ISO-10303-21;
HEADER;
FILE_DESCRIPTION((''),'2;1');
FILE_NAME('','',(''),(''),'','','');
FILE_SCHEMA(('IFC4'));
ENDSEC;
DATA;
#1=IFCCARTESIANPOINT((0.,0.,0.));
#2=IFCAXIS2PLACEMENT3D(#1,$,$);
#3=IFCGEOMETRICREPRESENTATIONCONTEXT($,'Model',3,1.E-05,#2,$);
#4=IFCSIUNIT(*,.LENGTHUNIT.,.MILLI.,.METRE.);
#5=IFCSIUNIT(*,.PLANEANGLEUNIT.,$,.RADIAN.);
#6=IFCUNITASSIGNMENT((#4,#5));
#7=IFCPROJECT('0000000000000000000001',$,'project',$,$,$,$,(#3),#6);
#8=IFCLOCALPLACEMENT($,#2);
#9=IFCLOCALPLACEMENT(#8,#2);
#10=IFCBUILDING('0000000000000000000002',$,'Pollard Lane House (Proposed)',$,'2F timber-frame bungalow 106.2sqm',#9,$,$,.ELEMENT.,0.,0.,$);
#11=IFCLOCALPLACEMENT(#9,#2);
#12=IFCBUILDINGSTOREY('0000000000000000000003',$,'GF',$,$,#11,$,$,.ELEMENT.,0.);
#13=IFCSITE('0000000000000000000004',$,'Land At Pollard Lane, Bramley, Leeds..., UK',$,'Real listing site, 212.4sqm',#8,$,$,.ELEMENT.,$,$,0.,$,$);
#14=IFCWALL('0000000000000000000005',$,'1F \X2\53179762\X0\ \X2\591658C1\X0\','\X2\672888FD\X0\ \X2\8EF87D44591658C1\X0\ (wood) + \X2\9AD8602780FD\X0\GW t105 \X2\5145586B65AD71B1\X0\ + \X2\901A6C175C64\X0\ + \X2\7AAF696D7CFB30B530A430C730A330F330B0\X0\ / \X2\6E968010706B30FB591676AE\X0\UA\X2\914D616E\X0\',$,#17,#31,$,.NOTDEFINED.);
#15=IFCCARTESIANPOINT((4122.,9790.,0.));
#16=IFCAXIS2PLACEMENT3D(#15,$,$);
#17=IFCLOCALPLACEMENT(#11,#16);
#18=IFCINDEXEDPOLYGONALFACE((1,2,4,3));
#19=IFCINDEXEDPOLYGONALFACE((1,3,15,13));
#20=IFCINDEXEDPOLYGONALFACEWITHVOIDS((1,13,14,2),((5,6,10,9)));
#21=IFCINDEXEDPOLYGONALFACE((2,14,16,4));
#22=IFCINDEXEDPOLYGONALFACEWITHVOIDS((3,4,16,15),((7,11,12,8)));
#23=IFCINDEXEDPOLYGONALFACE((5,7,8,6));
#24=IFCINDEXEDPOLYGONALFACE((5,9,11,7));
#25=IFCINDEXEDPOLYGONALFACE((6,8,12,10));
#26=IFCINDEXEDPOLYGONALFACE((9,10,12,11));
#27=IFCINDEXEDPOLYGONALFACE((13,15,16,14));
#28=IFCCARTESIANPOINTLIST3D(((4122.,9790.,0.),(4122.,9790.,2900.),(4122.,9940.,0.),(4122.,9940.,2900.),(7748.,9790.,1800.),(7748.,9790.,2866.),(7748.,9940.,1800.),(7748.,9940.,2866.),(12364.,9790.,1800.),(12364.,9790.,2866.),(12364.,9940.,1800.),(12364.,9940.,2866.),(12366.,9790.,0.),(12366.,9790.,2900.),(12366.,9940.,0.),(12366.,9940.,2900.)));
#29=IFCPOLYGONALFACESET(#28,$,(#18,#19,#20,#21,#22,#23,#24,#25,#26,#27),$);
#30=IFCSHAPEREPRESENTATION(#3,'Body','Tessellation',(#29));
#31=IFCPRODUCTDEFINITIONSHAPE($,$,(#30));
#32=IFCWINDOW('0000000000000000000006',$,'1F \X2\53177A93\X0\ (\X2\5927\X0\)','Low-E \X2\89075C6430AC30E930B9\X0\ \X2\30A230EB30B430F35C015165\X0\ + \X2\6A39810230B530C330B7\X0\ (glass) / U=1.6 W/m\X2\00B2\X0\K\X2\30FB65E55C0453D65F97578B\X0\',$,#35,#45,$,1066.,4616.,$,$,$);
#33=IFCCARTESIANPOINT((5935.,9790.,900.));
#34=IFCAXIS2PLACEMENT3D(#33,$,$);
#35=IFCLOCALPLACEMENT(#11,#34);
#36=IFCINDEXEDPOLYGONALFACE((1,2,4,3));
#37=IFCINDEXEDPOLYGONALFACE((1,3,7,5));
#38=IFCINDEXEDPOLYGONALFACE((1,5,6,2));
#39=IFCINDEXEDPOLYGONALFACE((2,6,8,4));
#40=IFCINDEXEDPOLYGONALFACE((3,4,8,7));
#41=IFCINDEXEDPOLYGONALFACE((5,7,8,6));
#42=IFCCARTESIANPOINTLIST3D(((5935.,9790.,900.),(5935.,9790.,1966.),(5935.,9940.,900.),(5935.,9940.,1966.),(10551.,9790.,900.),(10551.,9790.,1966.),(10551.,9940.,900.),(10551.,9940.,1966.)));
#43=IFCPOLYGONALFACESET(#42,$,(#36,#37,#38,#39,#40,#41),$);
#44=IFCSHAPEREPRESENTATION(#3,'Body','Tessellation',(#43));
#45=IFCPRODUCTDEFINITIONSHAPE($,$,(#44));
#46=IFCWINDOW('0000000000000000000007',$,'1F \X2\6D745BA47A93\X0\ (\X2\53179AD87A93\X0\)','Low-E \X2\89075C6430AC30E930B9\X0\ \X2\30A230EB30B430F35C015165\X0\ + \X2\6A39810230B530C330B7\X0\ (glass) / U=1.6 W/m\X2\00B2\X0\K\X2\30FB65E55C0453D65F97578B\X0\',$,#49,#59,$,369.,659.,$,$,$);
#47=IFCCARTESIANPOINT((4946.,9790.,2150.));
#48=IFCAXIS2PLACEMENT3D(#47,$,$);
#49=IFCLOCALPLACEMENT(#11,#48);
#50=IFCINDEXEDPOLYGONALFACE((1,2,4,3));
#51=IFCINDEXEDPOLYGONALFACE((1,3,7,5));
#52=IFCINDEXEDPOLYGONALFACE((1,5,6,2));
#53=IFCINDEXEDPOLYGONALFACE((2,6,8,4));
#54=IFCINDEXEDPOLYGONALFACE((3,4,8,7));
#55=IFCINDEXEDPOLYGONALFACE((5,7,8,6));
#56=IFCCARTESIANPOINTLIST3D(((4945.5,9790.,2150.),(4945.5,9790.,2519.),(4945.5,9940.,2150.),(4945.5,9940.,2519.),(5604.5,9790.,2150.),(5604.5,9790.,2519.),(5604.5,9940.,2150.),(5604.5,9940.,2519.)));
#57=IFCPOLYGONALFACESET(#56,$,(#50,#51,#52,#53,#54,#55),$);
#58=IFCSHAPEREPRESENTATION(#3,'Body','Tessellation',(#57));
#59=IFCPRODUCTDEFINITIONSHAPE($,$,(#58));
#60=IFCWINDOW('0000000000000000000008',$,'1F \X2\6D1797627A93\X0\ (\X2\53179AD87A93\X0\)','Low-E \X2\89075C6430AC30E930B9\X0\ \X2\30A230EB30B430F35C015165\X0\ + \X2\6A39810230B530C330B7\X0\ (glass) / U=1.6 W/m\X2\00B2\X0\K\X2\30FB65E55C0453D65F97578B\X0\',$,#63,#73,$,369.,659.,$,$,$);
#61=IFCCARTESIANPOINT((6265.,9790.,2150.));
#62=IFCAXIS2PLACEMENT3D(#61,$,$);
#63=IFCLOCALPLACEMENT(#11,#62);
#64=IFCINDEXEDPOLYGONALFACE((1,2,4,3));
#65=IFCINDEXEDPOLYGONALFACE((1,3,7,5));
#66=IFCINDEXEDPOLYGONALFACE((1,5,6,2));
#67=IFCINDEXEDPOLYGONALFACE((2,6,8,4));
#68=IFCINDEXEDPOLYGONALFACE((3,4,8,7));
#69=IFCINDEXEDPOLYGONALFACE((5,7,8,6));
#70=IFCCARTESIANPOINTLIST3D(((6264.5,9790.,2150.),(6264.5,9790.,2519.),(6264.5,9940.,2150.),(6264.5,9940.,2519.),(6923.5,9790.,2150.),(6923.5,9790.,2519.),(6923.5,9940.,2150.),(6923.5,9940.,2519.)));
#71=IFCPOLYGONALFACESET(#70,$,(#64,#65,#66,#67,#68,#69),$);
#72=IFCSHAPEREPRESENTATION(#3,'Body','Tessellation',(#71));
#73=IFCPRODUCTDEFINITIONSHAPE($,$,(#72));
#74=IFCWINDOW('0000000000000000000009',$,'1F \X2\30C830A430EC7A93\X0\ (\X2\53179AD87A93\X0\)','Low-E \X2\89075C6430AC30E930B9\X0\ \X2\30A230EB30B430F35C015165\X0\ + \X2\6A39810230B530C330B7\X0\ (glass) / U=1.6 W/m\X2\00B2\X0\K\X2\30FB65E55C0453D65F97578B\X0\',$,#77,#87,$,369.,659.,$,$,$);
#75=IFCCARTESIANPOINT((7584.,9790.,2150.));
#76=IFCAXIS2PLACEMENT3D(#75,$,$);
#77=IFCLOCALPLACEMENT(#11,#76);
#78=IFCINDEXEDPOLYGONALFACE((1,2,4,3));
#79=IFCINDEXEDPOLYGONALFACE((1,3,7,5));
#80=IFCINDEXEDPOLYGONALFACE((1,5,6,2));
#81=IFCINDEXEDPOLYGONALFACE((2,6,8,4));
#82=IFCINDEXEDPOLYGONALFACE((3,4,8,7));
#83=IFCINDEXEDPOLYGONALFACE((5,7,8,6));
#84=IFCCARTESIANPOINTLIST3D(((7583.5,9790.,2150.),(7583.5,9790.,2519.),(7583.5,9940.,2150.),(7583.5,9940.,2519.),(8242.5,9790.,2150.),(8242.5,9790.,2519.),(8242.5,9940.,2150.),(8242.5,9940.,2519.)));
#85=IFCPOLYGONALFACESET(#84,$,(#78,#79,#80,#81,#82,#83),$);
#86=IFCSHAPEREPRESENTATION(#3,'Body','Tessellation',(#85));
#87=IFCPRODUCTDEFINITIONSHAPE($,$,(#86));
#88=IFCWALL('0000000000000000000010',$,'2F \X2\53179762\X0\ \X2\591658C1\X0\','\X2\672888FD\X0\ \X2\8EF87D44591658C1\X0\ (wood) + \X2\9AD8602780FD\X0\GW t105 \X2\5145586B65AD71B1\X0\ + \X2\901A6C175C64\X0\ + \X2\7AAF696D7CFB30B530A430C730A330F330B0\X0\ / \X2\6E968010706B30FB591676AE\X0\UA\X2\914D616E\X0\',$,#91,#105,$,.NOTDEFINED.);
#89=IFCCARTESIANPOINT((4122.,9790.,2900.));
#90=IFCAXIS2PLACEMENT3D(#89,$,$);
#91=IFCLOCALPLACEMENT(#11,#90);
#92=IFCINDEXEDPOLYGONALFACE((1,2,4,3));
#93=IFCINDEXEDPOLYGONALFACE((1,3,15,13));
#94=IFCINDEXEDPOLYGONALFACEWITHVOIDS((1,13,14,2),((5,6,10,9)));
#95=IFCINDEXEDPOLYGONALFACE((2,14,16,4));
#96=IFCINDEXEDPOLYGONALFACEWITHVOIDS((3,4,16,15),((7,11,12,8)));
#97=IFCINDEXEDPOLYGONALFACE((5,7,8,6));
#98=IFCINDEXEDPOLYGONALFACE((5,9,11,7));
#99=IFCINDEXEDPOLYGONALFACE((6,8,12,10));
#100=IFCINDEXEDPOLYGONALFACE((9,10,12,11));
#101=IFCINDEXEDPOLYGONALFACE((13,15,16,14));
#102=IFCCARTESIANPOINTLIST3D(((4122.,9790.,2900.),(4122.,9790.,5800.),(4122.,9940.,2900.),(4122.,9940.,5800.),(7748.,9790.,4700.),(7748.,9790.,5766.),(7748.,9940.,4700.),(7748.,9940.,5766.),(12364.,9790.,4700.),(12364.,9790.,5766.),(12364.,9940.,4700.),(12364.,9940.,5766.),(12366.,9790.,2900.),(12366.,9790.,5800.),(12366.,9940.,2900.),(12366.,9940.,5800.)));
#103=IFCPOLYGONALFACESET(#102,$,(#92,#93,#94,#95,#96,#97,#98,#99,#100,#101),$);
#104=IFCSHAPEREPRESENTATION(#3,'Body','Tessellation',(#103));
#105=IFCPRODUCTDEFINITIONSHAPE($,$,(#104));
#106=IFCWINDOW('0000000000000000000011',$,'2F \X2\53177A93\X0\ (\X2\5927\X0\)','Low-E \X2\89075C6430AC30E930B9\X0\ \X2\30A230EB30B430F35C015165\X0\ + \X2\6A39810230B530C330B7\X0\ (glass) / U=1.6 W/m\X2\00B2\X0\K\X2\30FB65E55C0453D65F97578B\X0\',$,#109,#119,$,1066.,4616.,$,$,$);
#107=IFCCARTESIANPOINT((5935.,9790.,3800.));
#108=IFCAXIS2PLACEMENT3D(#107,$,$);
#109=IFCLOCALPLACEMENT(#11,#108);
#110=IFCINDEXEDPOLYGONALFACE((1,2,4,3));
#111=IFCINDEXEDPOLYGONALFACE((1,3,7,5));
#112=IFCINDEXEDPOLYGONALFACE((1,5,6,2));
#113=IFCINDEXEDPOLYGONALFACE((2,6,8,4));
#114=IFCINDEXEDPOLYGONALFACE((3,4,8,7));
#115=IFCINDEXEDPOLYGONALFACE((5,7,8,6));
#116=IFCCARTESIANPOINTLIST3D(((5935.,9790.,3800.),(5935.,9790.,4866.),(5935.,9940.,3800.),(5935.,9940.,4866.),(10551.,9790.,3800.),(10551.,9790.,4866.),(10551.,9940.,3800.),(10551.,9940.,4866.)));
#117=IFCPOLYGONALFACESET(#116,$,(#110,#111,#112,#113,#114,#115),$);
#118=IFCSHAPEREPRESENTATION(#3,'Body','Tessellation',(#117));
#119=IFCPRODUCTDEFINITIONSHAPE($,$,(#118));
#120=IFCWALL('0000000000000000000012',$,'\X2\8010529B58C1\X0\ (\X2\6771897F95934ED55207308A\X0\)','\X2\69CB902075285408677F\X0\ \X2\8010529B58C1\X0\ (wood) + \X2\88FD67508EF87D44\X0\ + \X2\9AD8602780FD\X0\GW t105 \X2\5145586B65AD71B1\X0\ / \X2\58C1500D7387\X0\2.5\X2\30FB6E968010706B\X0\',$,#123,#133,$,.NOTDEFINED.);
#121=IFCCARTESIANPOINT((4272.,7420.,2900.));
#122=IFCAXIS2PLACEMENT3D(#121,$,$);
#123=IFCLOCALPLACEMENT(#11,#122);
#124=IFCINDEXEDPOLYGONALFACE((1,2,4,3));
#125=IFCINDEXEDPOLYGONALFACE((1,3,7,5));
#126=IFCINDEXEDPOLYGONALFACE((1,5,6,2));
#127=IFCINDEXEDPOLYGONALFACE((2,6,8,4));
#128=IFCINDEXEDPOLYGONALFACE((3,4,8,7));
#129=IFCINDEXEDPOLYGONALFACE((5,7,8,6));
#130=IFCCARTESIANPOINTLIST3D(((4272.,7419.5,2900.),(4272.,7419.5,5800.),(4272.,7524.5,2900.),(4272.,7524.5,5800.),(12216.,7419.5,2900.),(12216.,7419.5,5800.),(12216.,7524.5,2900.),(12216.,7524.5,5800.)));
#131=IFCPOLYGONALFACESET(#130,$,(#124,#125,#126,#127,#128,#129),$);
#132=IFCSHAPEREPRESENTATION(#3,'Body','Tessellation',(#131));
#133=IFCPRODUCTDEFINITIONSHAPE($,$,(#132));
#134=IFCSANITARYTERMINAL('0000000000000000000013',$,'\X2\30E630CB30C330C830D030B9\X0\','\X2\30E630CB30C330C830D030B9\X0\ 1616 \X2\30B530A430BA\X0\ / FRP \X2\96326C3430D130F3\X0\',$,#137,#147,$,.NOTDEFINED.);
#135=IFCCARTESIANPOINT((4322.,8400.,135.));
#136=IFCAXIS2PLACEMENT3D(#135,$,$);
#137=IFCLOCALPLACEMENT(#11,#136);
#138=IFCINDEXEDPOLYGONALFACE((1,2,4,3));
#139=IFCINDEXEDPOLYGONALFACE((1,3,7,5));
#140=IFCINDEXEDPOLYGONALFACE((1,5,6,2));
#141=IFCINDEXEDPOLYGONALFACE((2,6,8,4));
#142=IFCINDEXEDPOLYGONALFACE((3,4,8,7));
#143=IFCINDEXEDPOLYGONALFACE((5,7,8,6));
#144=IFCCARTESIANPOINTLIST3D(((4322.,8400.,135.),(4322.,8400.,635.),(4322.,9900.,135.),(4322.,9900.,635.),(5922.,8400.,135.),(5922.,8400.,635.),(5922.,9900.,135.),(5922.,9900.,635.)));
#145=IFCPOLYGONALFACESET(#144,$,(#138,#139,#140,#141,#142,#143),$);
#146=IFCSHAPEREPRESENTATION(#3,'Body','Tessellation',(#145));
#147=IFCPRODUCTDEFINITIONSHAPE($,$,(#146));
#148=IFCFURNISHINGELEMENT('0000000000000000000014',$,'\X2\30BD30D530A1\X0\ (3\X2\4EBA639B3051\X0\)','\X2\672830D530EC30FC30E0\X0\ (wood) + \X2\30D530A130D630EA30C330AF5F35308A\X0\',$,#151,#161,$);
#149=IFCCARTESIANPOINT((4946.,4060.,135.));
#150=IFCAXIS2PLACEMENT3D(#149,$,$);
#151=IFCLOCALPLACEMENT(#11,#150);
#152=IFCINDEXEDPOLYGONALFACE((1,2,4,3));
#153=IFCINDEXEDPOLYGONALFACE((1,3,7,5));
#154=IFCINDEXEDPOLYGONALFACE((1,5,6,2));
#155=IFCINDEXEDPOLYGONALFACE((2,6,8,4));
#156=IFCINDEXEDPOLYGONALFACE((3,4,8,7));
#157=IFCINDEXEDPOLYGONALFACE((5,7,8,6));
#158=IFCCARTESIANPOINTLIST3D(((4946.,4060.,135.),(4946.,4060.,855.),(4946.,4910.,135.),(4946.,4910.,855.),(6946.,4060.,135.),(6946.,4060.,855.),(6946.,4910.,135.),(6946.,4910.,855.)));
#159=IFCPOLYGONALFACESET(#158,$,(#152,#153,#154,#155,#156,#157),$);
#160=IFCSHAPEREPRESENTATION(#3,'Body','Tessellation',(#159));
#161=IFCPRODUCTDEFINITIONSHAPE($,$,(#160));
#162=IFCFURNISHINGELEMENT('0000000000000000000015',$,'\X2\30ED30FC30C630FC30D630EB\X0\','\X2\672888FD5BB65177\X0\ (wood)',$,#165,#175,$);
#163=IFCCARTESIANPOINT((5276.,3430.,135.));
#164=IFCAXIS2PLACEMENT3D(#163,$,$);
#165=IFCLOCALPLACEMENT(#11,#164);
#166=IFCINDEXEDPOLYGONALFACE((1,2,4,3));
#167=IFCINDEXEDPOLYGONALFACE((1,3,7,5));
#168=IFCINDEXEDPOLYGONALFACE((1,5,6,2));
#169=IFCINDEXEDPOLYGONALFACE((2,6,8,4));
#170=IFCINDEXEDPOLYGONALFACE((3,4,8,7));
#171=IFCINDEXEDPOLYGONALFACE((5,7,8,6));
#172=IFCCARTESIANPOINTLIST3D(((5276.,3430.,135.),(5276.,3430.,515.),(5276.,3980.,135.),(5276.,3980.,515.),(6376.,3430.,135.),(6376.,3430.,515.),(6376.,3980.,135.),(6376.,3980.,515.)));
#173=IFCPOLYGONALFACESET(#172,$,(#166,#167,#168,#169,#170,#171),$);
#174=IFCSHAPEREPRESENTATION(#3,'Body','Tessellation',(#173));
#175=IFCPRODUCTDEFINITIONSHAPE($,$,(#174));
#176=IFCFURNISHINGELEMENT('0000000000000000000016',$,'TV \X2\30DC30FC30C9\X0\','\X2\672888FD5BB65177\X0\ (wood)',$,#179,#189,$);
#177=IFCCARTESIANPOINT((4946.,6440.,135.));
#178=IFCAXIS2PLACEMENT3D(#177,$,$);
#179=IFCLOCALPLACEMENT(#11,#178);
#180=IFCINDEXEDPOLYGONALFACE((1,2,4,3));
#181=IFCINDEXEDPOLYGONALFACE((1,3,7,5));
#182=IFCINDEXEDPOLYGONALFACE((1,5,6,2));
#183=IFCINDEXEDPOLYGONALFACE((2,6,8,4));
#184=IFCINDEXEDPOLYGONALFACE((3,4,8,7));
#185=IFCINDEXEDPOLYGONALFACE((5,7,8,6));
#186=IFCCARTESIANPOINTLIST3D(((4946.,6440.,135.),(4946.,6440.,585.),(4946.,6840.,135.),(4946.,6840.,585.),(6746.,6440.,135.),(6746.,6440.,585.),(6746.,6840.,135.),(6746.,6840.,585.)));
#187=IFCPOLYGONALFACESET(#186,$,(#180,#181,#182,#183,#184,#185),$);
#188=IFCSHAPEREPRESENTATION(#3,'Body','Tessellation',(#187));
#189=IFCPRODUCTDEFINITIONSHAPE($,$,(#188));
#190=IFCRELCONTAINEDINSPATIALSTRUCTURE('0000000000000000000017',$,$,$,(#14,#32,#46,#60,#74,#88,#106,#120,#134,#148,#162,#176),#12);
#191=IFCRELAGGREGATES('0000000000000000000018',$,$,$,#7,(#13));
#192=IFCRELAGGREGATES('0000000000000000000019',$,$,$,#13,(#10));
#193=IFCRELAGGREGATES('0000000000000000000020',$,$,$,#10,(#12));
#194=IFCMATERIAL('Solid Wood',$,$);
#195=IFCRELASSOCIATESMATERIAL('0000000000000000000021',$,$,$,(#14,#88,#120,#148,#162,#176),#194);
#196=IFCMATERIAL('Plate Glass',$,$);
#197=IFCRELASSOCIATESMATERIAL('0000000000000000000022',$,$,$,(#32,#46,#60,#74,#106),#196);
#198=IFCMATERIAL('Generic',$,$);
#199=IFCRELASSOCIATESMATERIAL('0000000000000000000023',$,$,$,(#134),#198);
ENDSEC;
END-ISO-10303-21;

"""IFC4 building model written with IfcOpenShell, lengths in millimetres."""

from ifc_helpers import new_model, si_unit, frame, frame_2d, origin, place, context, project, spatial, rectangle, extrude, material, element, fill, save


model = new_model("IFC4")

# Units and contexts
model_context = context("Model", 3, precision=1e-05, world=origin())
ifc_project = project(units=[si_unit("LENGTHUNIT", "METRE", prefix="MILLI"), si_unit("PLANEANGLEUNIT", "RADIAN")], contexts=[model_context])

# Site, building, storey
site_placement = place(None, origin())
site = spatial("IfcSite", under=ifc_project, at=site_placement, Name="Land At Pollard Lane, Bramley, Leeds..., UK", ObjectType="Real listing site, 212.4sqm", CompositionType="ELEMENT", RefElevation=0.0)
building_placement = place(site_placement, origin())
building = spatial("IfcBuilding", under=site, at=building_placement, Name="Pollard Lane House (Proposed)", ObjectType="2F timber-frame bungalow 106.2sqm", CompositionType="ELEMENT", ElevationOfRefHeight=0.0, ElevationOfTerrain=0.0)
storey_placement = place(building_placement, origin())
storey = spatial("IfcBuildingStorey", under=building, at=storey_placement, Name="GF", CompositionType="ELEMENT", Elevation=0.0)

# Wall, openings, windows
ifc_material_1 = material(Name="Solid Wood")
wall_1_placement = place(storey_placement, frame((4122.0, 9790.0, 0.0)))
wall_1 = element("IfcWall", 1, at=wall_1_placement, inside=storey, material=ifc_material_1, Name="1F 北面 外壁", Description="木製 軸組外壁 (wood) + 高性能GW t105 充填断熱 + 通気層 + 窯業系サイディング / 準耐火・外皮UA配慮", PredefinedType="NOTDEFINED", context=model_context, shape_type="SweptSolid", body=[
    extrude(rectangle(XDim=8244.0, YDim=150.0, at=frame_2d((4122.0, 75.0))), frame((4122.0, 9790.0, 0.0)), (0.0, 0.0, 1.0), 2900.0),
])
opening_1_placement = place(storey_placement, frame((5935.0, 9790.0, 900.0)))
opening_1 = element("IfcOpeningElement", 2, at=opening_1_placement, cuts=wall_1, PredefinedType="NOTDEFINED", context=model_context, shape_type="SweptSolid", body=[
    extrude(rectangle(XDim=4616.0, YDim=150.0, at=frame_2d((2308.0, 75.0))), frame((5935.0, 9790.0, 900.0)), (0.0, 0.0, 1.0), 1066.0),
])
opening_2_placement = place(storey_placement, frame((4946.0, 9790.0, 2150.0)))
opening_2 = element("IfcOpeningElement", 3, at=opening_2_placement, cuts=wall_1, PredefinedType="NOTDEFINED", context=model_context, shape_type="SweptSolid", body=[
    extrude(rectangle(XDim=659.0, YDim=150.0, at=frame_2d((329.0, 75.0))), frame((4946.0, 9790.0, 2150.0)), (0.0, 0.0, 1.0), 369.0),
])
opening_3_placement = place(storey_placement, frame((6265.0, 9790.0, 2150.0)))
opening_3 = element("IfcOpeningElement", 4, at=opening_3_placement, cuts=wall_1, PredefinedType="NOTDEFINED", context=model_context, shape_type="SweptSolid", body=[
    extrude(rectangle(XDim=659.0, YDim=150.0, at=frame_2d((329.0, 75.0))), frame((6265.0, 9790.0, 2150.0)), (0.0, 0.0, 1.0), 369.0),
])
opening_4_placement = place(storey_placement, frame((7584.0, 9790.0, 2150.0)))
opening_4 = element("IfcOpeningElement", 5, at=opening_4_placement, cuts=wall_1, PredefinedType="NOTDEFINED", context=model_context, shape_type="SweptSolid", body=[
    extrude(rectangle(XDim=659.0, YDim=150.0, at=frame_2d((329.0, 75.0))), frame((7584.0, 9790.0, 2150.0)), (0.0, 0.0, 1.0), 369.0),
])
ifc_material_2 = material(Name="Plate Glass")
window_1_placement = place(storey_placement, frame((5935.0, 9790.0, 900.0)))
window_1 = element("IfcWindow", 6, at=window_1_placement, inside=storey, material=ifc_material_2, Name="1F 北窓 (大)", Description="Low-E 複層ガラス アルゴン封入 + 樹脂サッシ (glass) / U=1.6 W/m²K・日射取得型", OverallHeight=1066.0, OverallWidth=4616.0, context=model_context, shape_type="SweptSolid", body=[
    extrude(rectangle(XDim=4616.0, YDim=150.0, at=frame_2d((2308.0, 75.0))), frame((5935.0, 9790.0, 900.0)), (0.0, 0.0, 1.0), 1066.0),
])
fill(opening_1, window_1)
window_2_placement = place(storey_placement, frame((4946.0, 9790.0, 2150.0)))
window_2 = element("IfcWindow", 7, at=window_2_placement, inside=storey, material=ifc_material_2, Name="1F 浴室窓 (北高窓)", Description="Low-E 複層ガラス アルゴン封入 + 樹脂サッシ (glass) / U=1.6 W/m²K・日射取得型", OverallHeight=369.0, OverallWidth=659.0, context=model_context, shape_type="SweptSolid", body=[
    extrude(rectangle(XDim=659.0, YDim=150.0, at=frame_2d((329.0, 75.0))), frame((4946.0, 9790.0, 2150.0)), (0.0, 0.0, 1.0), 369.0),
])
fill(opening_2, window_2)
window_3_placement = place(storey_placement, frame((6265.0, 9790.0, 2150.0)))
window_3 = element("IfcWindow", 8, at=window_3_placement, inside=storey, material=ifc_material_2, Name="1F 洗面窓 (北高窓)", Description="Low-E 複層ガラス アルゴン封入 + 樹脂サッシ (glass) / U=1.6 W/m²K・日射取得型", OverallHeight=369.0, OverallWidth=659.0, context=model_context, shape_type="SweptSolid", body=[
    extrude(rectangle(XDim=659.0, YDim=150.0, at=frame_2d((329.0, 75.0))), frame((6265.0, 9790.0, 2150.0)), (0.0, 0.0, 1.0), 369.0),
])
fill(opening_3, window_3)
window_4_placement = place(storey_placement, frame((7584.0, 9790.0, 2150.0)))
window_4 = element("IfcWindow", 9, at=window_4_placement, inside=storey, material=ifc_material_2, Name="1F トイレ窓 (北高窓)", Description="Low-E 複層ガラス アルゴン封入 + 樹脂サッシ (glass) / U=1.6 W/m²K・日射取得型", OverallHeight=369.0, OverallWidth=659.0, context=model_context, shape_type="SweptSolid", body=[
    extrude(rectangle(XDim=659.0, YDim=150.0, at=frame_2d((329.0, 75.0))), frame((7584.0, 9790.0, 2150.0)), (0.0, 0.0, 1.0), 369.0),
])
fill(opening_4, window_4)

# Wall, opening, window
wall_2_placement = place(storey_placement, frame((4122.0, 9790.0, 2900.0)))
wall_2 = element("IfcWall", 10, at=wall_2_placement, inside=storey, material=ifc_material_1, Name="2F 北面 外壁", Description="木製 軸組外壁 (wood) + 高性能GW t105 充填断熱 + 通気層 + 窯業系サイディング / 準耐火・外皮UA配慮", PredefinedType="NOTDEFINED", context=model_context, shape_type="SweptSolid", body=[
    extrude(rectangle(XDim=8244.0, YDim=150.0, at=frame_2d((4122.0, 75.0))), frame((4122.0, 9790.0, 2900.0)), (0.0, 0.0, 1.0), 2900.0),
])
opening_5_placement = place(storey_placement, frame((5935.0, 9790.0, 3800.0)))
opening_5 = element("IfcOpeningElement", 11, at=opening_5_placement, cuts=wall_2, PredefinedType="NOTDEFINED", context=model_context, shape_type="SweptSolid", body=[
    extrude(rectangle(XDim=4616.0, YDim=150.0, at=frame_2d((2308.0, 75.0))), frame((5935.0, 9790.0, 3800.0)), (0.0, 0.0, 1.0), 1066.0),
])
window_5_placement = place(storey_placement, frame((5935.0, 9790.0, 3800.0)))
window_5 = element("IfcWindow", 12, at=window_5_placement, inside=storey, material=ifc_material_2, Name="2F 北窓 (大)", Description="Low-E 複層ガラス アルゴン封入 + 樹脂サッシ (glass) / U=1.6 W/m²K・日射取得型", OverallHeight=1066.0, OverallWidth=4616.0, context=model_context, shape_type="SweptSolid", body=[
    extrude(rectangle(XDim=4616.0, YDim=150.0, at=frame_2d((2308.0, 75.0))), frame((5935.0, 9790.0, 3800.0)), (0.0, 0.0, 1.0), 1066.0),
])
fill(opening_5, window_5)

# Wall
wall_3_placement = place(storey_placement, frame((4272.0, 7420.0, 2900.0)))
element("IfcWall", 13, at=wall_3_placement, inside=storey, material=ifc_material_1, Name="耐力壁 (東西間仕切り)", Description="構造用合板 耐力壁 (wood) + 製材軸組 + 高性能GW t105 充填断熱 / 壁倍率2.5・準耐火", PredefinedType="NOTDEFINED", context=model_context, shape_type="SweptSolid", body=[
    extrude(rectangle(XDim=7944.0, YDim=105.0, at=frame_2d((3972.0, 52.0))), frame((4272.0, 7420.0, 2900.0)), (0.0, 0.0, 1.0), 2900.0),
])

# Sanitary terminal
ifc_material_3 = material(Name="Generic")
sanitary_terminal_placement = place(storey_placement, frame((4322.0, 8400.0, 135.0)))
element("IfcSanitaryTerminal", 14, at=sanitary_terminal_placement, inside=storey, material=ifc_material_3, Name="ユニットバス", Description="ユニットバス 1616 サイズ / FRP 防水パン", PredefinedType="NOTDEFINED", context=model_context, shape_type="SweptSolid", body=[
    extrude(rectangle(XDim=1600.0, YDim=1500.0, at=frame_2d((800.0, 750.0))), frame((4322.0, 8400.0, 135.0)), (0.0, 0.0, 1.0), 500.0),
])

# Furnishing elements
furnishing_1_placement = place(storey_placement, frame((4946.0, 4060.0, 135.0)))
element("IfcFurnishingElement", 15, at=furnishing_1_placement, inside=storey, material=ifc_material_1, Name="ソファ (3人掛け)", Description="木フレーム (wood) + ファブリック張り", context=model_context, shape_type="SweptSolid", body=[
    extrude(rectangle(XDim=2000.0, YDim=850.0, at=frame_2d((1000.0, 425.0))), frame((4946.0, 4060.0, 135.0)), (0.0, 0.0, 1.0), 720.0),
])
furnishing_2_placement = place(storey_placement, frame((5276.0, 3430.0, 135.0)))
element("IfcFurnishingElement", 16, at=furnishing_2_placement, inside=storey, material=ifc_material_1, Name="ローテーブル", Description="木製家具 (wood)", context=model_context, shape_type="SweptSolid", body=[
    extrude(rectangle(XDim=1100.0, YDim=550.0, at=frame_2d((550.0, 275.0))), frame((5276.0, 3430.0, 135.0)), (0.0, 0.0, 1.0), 380.0),
])
furnishing_3_placement = place(storey_placement, frame((4946.0, 6440.0, 135.0)))
element("IfcFurnishingElement", 17, at=furnishing_3_placement, inside=storey, material=ifc_material_1, Name="TV ボード", Description="木製家具 (wood)", context=model_context, shape_type="SweptSolid", body=[
    extrude(rectangle(XDim=1800.0, YDim=400.0, at=frame_2d((900.0, 200.0))), frame((4946.0, 6440.0, 135.0)), (0.0, 0.0, 1.0), 450.0),
])

save(model, "model.ifc")
